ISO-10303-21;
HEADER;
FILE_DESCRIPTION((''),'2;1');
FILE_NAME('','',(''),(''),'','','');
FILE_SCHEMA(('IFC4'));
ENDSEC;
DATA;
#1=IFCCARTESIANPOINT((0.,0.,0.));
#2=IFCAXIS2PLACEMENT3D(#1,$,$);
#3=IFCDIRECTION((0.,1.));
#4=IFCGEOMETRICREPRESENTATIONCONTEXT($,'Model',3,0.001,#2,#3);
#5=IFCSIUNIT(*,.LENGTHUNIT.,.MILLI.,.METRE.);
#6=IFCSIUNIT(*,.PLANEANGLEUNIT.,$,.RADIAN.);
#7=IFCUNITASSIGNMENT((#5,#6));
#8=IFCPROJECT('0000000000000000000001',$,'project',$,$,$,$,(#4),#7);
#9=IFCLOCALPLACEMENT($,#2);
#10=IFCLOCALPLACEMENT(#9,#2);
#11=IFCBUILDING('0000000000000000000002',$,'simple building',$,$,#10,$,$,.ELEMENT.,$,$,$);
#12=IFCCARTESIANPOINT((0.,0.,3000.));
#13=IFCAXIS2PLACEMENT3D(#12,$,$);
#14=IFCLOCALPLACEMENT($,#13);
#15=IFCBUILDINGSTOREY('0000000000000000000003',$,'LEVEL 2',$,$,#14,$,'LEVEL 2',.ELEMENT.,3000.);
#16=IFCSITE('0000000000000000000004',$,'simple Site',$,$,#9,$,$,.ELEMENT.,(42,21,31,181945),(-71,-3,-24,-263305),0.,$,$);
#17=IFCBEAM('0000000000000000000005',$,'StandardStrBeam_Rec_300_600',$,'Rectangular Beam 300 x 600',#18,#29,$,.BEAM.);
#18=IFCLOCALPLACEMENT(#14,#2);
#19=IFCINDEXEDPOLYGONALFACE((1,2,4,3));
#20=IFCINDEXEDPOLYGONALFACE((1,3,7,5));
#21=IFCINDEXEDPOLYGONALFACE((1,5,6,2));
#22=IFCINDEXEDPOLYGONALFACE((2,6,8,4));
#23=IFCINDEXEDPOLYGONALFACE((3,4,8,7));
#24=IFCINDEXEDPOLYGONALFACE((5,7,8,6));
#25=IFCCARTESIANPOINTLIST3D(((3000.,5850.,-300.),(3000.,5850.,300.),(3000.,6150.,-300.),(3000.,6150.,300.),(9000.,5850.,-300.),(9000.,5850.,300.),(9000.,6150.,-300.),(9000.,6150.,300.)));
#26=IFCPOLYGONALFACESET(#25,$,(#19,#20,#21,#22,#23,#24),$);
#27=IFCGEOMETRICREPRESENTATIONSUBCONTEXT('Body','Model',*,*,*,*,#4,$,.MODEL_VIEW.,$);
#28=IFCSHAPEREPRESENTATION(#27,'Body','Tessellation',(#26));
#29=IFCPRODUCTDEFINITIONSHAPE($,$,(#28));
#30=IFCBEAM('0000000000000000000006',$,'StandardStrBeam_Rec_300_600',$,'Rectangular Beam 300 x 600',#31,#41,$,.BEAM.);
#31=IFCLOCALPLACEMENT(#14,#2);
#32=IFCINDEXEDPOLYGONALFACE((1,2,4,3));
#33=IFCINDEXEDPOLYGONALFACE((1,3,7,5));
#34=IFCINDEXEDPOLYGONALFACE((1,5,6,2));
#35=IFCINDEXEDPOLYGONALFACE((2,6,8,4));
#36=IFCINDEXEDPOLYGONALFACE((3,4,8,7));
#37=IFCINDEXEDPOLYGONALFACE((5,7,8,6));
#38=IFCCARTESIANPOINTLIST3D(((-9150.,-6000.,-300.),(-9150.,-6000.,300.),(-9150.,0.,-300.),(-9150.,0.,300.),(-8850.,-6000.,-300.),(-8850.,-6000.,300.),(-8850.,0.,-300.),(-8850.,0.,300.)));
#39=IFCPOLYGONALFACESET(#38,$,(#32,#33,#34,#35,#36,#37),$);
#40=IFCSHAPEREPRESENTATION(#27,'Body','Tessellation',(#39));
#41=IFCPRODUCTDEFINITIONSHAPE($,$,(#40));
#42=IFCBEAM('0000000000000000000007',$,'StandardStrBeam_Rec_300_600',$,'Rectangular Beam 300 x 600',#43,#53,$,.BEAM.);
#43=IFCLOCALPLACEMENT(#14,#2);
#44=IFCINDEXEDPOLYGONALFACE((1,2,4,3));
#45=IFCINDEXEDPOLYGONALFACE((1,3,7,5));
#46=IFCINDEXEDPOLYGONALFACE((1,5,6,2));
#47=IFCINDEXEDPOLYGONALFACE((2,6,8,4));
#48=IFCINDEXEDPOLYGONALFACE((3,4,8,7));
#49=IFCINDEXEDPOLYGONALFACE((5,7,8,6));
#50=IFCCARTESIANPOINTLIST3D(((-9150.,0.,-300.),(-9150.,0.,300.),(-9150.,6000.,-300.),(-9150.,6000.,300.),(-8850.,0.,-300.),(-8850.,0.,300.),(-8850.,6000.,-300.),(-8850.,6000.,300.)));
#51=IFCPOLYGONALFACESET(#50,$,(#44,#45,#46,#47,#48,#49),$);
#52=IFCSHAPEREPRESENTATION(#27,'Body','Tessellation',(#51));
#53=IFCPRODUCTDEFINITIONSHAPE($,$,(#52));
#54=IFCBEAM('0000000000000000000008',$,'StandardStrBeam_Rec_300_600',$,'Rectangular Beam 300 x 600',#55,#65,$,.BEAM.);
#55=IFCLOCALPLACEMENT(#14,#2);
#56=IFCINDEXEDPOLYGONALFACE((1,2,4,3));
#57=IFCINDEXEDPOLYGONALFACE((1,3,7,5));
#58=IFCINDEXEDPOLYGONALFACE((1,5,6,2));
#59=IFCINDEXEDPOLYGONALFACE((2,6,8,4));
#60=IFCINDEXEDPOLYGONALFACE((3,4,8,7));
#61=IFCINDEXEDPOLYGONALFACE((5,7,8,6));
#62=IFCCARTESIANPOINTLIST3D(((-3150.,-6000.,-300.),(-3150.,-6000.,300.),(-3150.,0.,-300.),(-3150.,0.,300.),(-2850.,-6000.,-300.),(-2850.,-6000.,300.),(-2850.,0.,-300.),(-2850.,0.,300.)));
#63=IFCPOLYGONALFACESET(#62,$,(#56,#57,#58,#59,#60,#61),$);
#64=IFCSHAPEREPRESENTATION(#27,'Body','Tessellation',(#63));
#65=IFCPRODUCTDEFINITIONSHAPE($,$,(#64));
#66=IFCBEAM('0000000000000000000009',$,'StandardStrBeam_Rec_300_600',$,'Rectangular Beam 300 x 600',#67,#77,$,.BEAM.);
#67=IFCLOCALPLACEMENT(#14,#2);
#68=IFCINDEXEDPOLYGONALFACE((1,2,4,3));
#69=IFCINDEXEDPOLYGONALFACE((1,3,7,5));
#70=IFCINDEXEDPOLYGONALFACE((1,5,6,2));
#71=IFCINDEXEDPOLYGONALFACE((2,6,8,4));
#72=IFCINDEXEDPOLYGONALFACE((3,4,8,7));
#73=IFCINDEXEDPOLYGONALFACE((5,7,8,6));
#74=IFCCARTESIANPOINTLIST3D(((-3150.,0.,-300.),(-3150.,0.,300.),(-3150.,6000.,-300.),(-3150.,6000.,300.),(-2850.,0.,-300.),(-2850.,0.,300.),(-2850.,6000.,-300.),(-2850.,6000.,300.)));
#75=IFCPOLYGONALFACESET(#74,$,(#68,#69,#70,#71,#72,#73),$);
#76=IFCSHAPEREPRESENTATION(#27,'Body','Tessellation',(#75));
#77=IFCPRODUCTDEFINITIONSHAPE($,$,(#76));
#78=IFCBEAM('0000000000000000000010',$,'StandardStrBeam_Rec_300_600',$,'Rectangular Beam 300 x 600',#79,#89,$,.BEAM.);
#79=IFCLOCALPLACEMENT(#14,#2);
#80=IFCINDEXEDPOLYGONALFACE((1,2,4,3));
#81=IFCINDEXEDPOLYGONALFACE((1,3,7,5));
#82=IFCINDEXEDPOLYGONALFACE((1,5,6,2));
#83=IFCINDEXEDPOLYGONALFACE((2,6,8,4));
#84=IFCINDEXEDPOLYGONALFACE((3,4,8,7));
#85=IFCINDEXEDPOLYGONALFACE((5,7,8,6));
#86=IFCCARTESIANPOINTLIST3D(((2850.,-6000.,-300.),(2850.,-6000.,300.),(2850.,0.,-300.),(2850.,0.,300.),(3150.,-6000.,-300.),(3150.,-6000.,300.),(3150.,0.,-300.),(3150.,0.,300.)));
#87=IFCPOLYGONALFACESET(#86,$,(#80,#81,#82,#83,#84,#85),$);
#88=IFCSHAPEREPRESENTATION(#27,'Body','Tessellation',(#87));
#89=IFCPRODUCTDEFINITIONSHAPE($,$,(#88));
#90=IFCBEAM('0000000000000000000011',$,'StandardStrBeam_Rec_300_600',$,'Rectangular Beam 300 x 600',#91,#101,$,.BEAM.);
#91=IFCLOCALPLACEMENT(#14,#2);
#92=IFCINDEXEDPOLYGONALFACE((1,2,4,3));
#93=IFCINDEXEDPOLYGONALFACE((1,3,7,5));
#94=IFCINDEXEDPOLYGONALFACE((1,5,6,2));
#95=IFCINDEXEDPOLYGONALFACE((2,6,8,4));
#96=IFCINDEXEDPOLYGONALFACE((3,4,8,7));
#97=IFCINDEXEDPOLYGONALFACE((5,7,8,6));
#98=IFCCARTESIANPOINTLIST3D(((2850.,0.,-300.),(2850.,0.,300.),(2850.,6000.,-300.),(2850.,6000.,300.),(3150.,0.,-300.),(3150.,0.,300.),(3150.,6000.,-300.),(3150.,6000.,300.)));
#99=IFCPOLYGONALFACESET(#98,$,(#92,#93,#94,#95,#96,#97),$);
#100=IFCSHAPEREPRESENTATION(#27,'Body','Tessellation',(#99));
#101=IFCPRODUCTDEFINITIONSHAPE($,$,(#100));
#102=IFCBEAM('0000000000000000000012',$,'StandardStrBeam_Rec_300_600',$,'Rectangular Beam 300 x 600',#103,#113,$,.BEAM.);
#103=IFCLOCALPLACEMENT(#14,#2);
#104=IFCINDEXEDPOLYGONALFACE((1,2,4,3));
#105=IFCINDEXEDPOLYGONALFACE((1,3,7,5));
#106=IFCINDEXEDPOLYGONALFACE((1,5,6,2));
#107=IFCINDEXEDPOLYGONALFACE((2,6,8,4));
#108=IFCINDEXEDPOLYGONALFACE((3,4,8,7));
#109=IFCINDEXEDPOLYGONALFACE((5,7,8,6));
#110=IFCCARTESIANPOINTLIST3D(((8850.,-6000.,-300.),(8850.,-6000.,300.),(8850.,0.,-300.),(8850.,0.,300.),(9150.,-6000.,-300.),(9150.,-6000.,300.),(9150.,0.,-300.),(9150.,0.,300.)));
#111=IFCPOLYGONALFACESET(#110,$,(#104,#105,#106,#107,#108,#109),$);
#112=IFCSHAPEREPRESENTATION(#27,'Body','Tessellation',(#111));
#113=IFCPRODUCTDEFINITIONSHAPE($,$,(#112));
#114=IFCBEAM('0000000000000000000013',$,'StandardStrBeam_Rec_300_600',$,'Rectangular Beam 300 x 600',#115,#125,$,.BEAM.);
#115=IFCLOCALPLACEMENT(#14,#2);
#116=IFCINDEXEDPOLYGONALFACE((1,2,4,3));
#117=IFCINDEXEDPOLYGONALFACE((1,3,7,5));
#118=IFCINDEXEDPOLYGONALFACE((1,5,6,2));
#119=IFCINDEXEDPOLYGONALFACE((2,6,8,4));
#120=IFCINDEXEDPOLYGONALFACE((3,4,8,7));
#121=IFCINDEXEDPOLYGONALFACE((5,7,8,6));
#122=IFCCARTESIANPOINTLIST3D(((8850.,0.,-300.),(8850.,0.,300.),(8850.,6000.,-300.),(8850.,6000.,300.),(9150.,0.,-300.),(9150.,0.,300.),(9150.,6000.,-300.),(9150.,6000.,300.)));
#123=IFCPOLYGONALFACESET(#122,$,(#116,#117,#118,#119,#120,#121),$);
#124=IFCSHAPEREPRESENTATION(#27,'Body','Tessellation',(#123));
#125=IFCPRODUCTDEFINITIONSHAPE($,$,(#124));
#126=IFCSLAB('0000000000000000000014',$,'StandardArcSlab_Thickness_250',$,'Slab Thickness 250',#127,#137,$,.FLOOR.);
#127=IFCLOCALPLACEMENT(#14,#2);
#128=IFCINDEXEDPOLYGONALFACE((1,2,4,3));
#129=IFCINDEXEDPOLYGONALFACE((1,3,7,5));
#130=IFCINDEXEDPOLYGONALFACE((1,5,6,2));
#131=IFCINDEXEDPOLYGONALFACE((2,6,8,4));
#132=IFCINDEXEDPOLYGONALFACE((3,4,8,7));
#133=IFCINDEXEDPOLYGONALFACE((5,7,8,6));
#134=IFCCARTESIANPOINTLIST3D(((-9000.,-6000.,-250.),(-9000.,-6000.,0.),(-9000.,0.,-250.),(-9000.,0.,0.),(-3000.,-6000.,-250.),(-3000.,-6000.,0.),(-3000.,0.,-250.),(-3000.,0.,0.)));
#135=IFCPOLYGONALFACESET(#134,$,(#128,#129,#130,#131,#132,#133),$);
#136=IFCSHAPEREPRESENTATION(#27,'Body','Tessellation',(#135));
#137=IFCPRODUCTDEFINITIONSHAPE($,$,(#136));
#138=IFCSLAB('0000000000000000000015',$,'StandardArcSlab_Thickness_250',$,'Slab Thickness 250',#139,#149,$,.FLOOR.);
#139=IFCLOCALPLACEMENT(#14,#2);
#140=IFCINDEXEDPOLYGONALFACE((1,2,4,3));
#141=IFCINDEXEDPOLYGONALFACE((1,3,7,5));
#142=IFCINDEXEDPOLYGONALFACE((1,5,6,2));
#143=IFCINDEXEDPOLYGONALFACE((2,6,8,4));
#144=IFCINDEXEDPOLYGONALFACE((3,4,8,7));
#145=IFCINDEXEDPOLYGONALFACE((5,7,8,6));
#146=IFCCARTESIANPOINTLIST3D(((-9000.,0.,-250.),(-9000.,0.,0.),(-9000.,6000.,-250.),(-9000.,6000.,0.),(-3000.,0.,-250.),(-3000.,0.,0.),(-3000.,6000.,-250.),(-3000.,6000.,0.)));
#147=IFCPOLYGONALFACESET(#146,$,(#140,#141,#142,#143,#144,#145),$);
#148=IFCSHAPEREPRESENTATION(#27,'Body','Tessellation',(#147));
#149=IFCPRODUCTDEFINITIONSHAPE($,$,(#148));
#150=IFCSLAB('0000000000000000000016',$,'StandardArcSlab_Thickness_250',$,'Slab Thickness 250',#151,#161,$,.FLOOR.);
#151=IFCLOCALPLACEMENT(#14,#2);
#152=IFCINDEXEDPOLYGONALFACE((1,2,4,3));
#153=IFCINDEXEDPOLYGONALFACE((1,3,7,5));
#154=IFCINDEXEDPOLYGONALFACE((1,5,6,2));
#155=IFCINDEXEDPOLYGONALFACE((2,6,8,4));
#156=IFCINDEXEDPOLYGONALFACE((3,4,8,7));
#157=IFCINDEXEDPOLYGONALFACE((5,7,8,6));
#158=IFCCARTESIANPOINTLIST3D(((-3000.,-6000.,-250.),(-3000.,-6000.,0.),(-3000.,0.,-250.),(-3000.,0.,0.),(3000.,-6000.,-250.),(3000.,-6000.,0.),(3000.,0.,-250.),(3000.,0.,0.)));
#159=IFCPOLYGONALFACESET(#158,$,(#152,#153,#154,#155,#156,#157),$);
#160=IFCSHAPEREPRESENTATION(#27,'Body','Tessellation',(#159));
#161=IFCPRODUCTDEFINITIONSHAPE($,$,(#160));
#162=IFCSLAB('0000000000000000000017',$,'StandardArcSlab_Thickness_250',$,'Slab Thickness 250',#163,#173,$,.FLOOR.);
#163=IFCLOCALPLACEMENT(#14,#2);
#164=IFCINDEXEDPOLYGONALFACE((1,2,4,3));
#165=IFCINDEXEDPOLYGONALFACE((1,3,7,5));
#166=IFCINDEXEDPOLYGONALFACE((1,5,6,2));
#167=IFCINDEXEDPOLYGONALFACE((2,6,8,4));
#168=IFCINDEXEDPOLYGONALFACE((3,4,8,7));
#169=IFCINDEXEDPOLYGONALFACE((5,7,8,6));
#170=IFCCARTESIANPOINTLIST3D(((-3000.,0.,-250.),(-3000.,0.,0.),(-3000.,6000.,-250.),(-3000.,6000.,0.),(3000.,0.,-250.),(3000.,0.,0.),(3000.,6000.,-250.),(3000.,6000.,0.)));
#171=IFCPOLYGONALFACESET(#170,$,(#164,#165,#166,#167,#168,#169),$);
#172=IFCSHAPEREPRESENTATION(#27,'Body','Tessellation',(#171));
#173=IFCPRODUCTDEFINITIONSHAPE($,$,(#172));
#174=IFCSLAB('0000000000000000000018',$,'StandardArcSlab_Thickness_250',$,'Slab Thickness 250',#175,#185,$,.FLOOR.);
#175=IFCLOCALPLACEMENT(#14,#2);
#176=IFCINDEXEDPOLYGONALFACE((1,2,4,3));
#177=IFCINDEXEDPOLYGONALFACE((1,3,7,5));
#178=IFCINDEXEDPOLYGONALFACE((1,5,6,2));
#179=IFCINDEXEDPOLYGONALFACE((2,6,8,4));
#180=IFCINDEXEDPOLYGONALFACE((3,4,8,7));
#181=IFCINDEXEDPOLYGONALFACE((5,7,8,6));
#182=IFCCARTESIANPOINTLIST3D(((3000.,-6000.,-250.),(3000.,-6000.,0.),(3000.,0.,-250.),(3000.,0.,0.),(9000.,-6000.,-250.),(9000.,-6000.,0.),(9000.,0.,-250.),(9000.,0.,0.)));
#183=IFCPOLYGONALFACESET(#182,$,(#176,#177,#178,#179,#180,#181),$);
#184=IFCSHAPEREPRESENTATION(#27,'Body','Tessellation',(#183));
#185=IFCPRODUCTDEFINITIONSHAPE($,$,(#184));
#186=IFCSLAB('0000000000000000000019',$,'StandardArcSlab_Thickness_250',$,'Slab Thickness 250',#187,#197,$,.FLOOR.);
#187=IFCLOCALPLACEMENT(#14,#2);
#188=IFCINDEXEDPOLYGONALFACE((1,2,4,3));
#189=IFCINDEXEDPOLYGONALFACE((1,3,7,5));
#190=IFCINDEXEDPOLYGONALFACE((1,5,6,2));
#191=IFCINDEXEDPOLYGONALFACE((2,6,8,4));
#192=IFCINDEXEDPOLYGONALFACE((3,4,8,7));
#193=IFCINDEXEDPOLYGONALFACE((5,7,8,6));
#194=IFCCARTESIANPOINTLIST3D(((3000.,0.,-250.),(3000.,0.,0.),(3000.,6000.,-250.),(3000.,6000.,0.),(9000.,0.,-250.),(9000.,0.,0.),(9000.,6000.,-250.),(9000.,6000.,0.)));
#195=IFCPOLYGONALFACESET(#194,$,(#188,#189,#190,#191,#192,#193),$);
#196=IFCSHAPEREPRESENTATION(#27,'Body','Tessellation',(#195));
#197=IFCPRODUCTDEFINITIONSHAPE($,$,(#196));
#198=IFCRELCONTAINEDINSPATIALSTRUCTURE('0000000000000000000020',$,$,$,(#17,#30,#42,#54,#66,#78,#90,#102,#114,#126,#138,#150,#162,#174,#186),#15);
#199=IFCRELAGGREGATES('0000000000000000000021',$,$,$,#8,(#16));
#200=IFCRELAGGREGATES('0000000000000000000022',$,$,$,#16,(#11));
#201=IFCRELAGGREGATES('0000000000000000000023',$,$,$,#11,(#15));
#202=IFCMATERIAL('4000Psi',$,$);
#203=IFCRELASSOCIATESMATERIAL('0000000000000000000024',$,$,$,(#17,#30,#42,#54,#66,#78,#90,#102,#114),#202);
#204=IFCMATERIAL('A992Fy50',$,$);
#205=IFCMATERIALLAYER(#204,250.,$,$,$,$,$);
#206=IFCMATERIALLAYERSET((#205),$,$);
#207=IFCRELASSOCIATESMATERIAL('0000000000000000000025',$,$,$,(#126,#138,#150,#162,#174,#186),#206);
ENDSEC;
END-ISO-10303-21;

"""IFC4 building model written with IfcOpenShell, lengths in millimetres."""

from ifc_helpers import new_model, si_unit, direction, frame, origin, origin_with_axes, origin_2d_with_axis, place, context, subcontext, project, spatial, polyline, rectangle, outline, extrude, material, layer, layer_set, layer_usage, material_profile, profile_set, profile_usage, element, save


model = new_model("IFC4")

# Units and contexts
model_context = context("Model", 3, precision=0.001, world=origin(), true_north=direction((0.0, 1.0)))
body_context = subcontext(model_context, "Body", "Model", "MODEL_VIEW")
ifc_project = project(units=[si_unit("LENGTHUNIT", "METRE", prefix="MILLI"), si_unit("PLANEANGLEUNIT", "RADIAN")], contexts=[model_context])

# Site, building, storey
site_placement = place(None, origin())
site = spatial("IfcSite", under=ifc_project, at=site_placement, Name="simple Site", CompositionType="ELEMENT", RefLatitude=(42, 21, 31, 181945), RefLongitude=(-71, -3, -24, -263305), RefElevation=0.0)
building_placement = place(site_placement, origin())
building = spatial("IfcBuilding", under=site, at=building_placement, Name="simple building", CompositionType="ELEMENT")
storey_placement = place(None, frame((0.0, 0.0, 3000.0)))
storey = spatial("IfcBuildingStorey", under=building, at=storey_placement, Name="LEVEL 2", LongName="LEVEL 2", CompositionType="ELEMENT", Elevation=3000.0)

# Shared definitions
ifc_material_1 = material(Name="4000Psi")
ifc_material_profile = material_profile(ifc_material_1, rectangle(XDim=300.0, YDim=600.0, at=origin_2d_with_axis()))
ifc_profile_set = profile_set([ifc_material_profile])
ifc_profile_usage = profile_usage(ifc_profile_set, cardinal=10)

# Beams
for number, where, z_axis, x_axis, name in (
    (1, (3000.0, 6000.0, 3000.0), (1.0, 0.0, 0.0), (0.0, -1.0, 0.0), "StandardStrBeam_Rec_300_600"),
    (2, (-9000.0, -6000.0, 3000.0), (0.0, 1.0, 0.0), (1.0, 0.0, 0.0), "StandardStrBeam_Rec_300_600"),
    (3, (-9000.0, 0.0, 3000.0), (0.0, 1.0, 0.0), (1.0, 0.0, 0.0), "StandardStrBeam_Rec_300_600"),
    (4, (-3000.0, -6000.0, 3000.0), (0.0, 1.0, 0.0), (1.0, 0.0, 0.0), "StandardStrBeam_Rec_300_600"),
    (5, (-3000.0, 0.0, 3000.0), (0.0, 1.0, 0.0), (1.0, 0.0, 0.0), "StandardStrBeam_Rec_300_600"),
    (6, (3000.0, -6000.0, 3000.0), (0.0, 1.0, 0.0), (1.0, 0.0, 0.0), "StandardStrBeam_Rec_300_600"),
    (7, (3000.0, 0.0, 3000.0), (0.0, 1.0, 0.0), (1.0, 0.0, 0.0), "StandardStrBeam_Rec_300_600"),
    (8, (9000.0, -6000.0, 3000.0), (0.0, 1.0, 0.0), (1.0, 0.0, 0.0), "StandardStrBeam_Rec_300_600"),
    (9, (9000.0, 0.0, 3000.0), (0.0, 1.0, 0.0), (1.0, 0.0, 0.0), "StandardStrBeam_Rec_300_600"),
):
    element("IfcBeam", number, at=place(None, frame(where, z_axis=z_axis, x_axis=x_axis)), inside=storey, material=ifc_profile_usage, Name=name, ObjectType="Rectangular Beam 300 x 600", PredefinedType="BEAM", context=body_context, shape_type="SweptSolid", body=[
        extrude(rectangle(XDim=300.0, YDim=600.0, at=origin_2d_with_axis()), origin_with_axes(), (0.0, 0.0, 1.0), 6000.0),
    ])

# Slabs
ifc_material_2 = material(Name="A992Fy50")
ifc_layer = layer(ifc_material_2, 250.0)
ifc_layer_set = layer_set([ifc_layer])
ifc_layer_usage = layer_usage(ifc_layer_set, "AXIS3", "POSITIVE", -250.0)
for number, where, z_axis, x_axis, name in (
    (10, (-9000.0, -6000.0, 2750.0), (0.0, 0.0, 1.0), (1.0, 0.0, 0.0), "StandardArcSlab_Thickness_250"),
    (11, (-9000.0, 0.0, 2750.0), (0.0, 0.0, 1.0), (1.0, 0.0, 0.0), "StandardArcSlab_Thickness_250"),
    (12, (-3000.0, -6000.0, 2750.0), (0.0, 0.0, 1.0), (1.0, 0.0, 0.0), "StandardArcSlab_Thickness_250"),
    (13, (-3000.0, 0.0, 2750.0), (0.0, 0.0, 1.0), (1.0, 0.0, 0.0), "StandardArcSlab_Thickness_250"),
    (14, (3000.0, -6000.0, 2750.0), (0.0, 0.0, 1.0), (1.0, 0.0, 0.0), "StandardArcSlab_Thickness_250"),
    (15, (3000.0, 0.0, 2750.0), (0.0, 0.0, 1.0), (1.0, 0.0, 0.0), "StandardArcSlab_Thickness_250"),
):
    element("IfcSlab", number, at=place(None, frame(where, z_axis=z_axis, x_axis=x_axis)), inside=storey, material=ifc_layer_usage, Name=name, ObjectType="Slab Thickness 250", PredefinedType="FLOOR", context=body_context, shape_type="SweptSolid", body=[
        extrude(outline(polyline([(0.0, 0.0), (6000.0, 0.0), (6000.0, 6000.0), (0.0, 6000.0), (0.0, 0.0)])), origin_with_axes(), (0.0, 0.0, 1.0), 250.0),
    ])

save(model, "model.ifc")
